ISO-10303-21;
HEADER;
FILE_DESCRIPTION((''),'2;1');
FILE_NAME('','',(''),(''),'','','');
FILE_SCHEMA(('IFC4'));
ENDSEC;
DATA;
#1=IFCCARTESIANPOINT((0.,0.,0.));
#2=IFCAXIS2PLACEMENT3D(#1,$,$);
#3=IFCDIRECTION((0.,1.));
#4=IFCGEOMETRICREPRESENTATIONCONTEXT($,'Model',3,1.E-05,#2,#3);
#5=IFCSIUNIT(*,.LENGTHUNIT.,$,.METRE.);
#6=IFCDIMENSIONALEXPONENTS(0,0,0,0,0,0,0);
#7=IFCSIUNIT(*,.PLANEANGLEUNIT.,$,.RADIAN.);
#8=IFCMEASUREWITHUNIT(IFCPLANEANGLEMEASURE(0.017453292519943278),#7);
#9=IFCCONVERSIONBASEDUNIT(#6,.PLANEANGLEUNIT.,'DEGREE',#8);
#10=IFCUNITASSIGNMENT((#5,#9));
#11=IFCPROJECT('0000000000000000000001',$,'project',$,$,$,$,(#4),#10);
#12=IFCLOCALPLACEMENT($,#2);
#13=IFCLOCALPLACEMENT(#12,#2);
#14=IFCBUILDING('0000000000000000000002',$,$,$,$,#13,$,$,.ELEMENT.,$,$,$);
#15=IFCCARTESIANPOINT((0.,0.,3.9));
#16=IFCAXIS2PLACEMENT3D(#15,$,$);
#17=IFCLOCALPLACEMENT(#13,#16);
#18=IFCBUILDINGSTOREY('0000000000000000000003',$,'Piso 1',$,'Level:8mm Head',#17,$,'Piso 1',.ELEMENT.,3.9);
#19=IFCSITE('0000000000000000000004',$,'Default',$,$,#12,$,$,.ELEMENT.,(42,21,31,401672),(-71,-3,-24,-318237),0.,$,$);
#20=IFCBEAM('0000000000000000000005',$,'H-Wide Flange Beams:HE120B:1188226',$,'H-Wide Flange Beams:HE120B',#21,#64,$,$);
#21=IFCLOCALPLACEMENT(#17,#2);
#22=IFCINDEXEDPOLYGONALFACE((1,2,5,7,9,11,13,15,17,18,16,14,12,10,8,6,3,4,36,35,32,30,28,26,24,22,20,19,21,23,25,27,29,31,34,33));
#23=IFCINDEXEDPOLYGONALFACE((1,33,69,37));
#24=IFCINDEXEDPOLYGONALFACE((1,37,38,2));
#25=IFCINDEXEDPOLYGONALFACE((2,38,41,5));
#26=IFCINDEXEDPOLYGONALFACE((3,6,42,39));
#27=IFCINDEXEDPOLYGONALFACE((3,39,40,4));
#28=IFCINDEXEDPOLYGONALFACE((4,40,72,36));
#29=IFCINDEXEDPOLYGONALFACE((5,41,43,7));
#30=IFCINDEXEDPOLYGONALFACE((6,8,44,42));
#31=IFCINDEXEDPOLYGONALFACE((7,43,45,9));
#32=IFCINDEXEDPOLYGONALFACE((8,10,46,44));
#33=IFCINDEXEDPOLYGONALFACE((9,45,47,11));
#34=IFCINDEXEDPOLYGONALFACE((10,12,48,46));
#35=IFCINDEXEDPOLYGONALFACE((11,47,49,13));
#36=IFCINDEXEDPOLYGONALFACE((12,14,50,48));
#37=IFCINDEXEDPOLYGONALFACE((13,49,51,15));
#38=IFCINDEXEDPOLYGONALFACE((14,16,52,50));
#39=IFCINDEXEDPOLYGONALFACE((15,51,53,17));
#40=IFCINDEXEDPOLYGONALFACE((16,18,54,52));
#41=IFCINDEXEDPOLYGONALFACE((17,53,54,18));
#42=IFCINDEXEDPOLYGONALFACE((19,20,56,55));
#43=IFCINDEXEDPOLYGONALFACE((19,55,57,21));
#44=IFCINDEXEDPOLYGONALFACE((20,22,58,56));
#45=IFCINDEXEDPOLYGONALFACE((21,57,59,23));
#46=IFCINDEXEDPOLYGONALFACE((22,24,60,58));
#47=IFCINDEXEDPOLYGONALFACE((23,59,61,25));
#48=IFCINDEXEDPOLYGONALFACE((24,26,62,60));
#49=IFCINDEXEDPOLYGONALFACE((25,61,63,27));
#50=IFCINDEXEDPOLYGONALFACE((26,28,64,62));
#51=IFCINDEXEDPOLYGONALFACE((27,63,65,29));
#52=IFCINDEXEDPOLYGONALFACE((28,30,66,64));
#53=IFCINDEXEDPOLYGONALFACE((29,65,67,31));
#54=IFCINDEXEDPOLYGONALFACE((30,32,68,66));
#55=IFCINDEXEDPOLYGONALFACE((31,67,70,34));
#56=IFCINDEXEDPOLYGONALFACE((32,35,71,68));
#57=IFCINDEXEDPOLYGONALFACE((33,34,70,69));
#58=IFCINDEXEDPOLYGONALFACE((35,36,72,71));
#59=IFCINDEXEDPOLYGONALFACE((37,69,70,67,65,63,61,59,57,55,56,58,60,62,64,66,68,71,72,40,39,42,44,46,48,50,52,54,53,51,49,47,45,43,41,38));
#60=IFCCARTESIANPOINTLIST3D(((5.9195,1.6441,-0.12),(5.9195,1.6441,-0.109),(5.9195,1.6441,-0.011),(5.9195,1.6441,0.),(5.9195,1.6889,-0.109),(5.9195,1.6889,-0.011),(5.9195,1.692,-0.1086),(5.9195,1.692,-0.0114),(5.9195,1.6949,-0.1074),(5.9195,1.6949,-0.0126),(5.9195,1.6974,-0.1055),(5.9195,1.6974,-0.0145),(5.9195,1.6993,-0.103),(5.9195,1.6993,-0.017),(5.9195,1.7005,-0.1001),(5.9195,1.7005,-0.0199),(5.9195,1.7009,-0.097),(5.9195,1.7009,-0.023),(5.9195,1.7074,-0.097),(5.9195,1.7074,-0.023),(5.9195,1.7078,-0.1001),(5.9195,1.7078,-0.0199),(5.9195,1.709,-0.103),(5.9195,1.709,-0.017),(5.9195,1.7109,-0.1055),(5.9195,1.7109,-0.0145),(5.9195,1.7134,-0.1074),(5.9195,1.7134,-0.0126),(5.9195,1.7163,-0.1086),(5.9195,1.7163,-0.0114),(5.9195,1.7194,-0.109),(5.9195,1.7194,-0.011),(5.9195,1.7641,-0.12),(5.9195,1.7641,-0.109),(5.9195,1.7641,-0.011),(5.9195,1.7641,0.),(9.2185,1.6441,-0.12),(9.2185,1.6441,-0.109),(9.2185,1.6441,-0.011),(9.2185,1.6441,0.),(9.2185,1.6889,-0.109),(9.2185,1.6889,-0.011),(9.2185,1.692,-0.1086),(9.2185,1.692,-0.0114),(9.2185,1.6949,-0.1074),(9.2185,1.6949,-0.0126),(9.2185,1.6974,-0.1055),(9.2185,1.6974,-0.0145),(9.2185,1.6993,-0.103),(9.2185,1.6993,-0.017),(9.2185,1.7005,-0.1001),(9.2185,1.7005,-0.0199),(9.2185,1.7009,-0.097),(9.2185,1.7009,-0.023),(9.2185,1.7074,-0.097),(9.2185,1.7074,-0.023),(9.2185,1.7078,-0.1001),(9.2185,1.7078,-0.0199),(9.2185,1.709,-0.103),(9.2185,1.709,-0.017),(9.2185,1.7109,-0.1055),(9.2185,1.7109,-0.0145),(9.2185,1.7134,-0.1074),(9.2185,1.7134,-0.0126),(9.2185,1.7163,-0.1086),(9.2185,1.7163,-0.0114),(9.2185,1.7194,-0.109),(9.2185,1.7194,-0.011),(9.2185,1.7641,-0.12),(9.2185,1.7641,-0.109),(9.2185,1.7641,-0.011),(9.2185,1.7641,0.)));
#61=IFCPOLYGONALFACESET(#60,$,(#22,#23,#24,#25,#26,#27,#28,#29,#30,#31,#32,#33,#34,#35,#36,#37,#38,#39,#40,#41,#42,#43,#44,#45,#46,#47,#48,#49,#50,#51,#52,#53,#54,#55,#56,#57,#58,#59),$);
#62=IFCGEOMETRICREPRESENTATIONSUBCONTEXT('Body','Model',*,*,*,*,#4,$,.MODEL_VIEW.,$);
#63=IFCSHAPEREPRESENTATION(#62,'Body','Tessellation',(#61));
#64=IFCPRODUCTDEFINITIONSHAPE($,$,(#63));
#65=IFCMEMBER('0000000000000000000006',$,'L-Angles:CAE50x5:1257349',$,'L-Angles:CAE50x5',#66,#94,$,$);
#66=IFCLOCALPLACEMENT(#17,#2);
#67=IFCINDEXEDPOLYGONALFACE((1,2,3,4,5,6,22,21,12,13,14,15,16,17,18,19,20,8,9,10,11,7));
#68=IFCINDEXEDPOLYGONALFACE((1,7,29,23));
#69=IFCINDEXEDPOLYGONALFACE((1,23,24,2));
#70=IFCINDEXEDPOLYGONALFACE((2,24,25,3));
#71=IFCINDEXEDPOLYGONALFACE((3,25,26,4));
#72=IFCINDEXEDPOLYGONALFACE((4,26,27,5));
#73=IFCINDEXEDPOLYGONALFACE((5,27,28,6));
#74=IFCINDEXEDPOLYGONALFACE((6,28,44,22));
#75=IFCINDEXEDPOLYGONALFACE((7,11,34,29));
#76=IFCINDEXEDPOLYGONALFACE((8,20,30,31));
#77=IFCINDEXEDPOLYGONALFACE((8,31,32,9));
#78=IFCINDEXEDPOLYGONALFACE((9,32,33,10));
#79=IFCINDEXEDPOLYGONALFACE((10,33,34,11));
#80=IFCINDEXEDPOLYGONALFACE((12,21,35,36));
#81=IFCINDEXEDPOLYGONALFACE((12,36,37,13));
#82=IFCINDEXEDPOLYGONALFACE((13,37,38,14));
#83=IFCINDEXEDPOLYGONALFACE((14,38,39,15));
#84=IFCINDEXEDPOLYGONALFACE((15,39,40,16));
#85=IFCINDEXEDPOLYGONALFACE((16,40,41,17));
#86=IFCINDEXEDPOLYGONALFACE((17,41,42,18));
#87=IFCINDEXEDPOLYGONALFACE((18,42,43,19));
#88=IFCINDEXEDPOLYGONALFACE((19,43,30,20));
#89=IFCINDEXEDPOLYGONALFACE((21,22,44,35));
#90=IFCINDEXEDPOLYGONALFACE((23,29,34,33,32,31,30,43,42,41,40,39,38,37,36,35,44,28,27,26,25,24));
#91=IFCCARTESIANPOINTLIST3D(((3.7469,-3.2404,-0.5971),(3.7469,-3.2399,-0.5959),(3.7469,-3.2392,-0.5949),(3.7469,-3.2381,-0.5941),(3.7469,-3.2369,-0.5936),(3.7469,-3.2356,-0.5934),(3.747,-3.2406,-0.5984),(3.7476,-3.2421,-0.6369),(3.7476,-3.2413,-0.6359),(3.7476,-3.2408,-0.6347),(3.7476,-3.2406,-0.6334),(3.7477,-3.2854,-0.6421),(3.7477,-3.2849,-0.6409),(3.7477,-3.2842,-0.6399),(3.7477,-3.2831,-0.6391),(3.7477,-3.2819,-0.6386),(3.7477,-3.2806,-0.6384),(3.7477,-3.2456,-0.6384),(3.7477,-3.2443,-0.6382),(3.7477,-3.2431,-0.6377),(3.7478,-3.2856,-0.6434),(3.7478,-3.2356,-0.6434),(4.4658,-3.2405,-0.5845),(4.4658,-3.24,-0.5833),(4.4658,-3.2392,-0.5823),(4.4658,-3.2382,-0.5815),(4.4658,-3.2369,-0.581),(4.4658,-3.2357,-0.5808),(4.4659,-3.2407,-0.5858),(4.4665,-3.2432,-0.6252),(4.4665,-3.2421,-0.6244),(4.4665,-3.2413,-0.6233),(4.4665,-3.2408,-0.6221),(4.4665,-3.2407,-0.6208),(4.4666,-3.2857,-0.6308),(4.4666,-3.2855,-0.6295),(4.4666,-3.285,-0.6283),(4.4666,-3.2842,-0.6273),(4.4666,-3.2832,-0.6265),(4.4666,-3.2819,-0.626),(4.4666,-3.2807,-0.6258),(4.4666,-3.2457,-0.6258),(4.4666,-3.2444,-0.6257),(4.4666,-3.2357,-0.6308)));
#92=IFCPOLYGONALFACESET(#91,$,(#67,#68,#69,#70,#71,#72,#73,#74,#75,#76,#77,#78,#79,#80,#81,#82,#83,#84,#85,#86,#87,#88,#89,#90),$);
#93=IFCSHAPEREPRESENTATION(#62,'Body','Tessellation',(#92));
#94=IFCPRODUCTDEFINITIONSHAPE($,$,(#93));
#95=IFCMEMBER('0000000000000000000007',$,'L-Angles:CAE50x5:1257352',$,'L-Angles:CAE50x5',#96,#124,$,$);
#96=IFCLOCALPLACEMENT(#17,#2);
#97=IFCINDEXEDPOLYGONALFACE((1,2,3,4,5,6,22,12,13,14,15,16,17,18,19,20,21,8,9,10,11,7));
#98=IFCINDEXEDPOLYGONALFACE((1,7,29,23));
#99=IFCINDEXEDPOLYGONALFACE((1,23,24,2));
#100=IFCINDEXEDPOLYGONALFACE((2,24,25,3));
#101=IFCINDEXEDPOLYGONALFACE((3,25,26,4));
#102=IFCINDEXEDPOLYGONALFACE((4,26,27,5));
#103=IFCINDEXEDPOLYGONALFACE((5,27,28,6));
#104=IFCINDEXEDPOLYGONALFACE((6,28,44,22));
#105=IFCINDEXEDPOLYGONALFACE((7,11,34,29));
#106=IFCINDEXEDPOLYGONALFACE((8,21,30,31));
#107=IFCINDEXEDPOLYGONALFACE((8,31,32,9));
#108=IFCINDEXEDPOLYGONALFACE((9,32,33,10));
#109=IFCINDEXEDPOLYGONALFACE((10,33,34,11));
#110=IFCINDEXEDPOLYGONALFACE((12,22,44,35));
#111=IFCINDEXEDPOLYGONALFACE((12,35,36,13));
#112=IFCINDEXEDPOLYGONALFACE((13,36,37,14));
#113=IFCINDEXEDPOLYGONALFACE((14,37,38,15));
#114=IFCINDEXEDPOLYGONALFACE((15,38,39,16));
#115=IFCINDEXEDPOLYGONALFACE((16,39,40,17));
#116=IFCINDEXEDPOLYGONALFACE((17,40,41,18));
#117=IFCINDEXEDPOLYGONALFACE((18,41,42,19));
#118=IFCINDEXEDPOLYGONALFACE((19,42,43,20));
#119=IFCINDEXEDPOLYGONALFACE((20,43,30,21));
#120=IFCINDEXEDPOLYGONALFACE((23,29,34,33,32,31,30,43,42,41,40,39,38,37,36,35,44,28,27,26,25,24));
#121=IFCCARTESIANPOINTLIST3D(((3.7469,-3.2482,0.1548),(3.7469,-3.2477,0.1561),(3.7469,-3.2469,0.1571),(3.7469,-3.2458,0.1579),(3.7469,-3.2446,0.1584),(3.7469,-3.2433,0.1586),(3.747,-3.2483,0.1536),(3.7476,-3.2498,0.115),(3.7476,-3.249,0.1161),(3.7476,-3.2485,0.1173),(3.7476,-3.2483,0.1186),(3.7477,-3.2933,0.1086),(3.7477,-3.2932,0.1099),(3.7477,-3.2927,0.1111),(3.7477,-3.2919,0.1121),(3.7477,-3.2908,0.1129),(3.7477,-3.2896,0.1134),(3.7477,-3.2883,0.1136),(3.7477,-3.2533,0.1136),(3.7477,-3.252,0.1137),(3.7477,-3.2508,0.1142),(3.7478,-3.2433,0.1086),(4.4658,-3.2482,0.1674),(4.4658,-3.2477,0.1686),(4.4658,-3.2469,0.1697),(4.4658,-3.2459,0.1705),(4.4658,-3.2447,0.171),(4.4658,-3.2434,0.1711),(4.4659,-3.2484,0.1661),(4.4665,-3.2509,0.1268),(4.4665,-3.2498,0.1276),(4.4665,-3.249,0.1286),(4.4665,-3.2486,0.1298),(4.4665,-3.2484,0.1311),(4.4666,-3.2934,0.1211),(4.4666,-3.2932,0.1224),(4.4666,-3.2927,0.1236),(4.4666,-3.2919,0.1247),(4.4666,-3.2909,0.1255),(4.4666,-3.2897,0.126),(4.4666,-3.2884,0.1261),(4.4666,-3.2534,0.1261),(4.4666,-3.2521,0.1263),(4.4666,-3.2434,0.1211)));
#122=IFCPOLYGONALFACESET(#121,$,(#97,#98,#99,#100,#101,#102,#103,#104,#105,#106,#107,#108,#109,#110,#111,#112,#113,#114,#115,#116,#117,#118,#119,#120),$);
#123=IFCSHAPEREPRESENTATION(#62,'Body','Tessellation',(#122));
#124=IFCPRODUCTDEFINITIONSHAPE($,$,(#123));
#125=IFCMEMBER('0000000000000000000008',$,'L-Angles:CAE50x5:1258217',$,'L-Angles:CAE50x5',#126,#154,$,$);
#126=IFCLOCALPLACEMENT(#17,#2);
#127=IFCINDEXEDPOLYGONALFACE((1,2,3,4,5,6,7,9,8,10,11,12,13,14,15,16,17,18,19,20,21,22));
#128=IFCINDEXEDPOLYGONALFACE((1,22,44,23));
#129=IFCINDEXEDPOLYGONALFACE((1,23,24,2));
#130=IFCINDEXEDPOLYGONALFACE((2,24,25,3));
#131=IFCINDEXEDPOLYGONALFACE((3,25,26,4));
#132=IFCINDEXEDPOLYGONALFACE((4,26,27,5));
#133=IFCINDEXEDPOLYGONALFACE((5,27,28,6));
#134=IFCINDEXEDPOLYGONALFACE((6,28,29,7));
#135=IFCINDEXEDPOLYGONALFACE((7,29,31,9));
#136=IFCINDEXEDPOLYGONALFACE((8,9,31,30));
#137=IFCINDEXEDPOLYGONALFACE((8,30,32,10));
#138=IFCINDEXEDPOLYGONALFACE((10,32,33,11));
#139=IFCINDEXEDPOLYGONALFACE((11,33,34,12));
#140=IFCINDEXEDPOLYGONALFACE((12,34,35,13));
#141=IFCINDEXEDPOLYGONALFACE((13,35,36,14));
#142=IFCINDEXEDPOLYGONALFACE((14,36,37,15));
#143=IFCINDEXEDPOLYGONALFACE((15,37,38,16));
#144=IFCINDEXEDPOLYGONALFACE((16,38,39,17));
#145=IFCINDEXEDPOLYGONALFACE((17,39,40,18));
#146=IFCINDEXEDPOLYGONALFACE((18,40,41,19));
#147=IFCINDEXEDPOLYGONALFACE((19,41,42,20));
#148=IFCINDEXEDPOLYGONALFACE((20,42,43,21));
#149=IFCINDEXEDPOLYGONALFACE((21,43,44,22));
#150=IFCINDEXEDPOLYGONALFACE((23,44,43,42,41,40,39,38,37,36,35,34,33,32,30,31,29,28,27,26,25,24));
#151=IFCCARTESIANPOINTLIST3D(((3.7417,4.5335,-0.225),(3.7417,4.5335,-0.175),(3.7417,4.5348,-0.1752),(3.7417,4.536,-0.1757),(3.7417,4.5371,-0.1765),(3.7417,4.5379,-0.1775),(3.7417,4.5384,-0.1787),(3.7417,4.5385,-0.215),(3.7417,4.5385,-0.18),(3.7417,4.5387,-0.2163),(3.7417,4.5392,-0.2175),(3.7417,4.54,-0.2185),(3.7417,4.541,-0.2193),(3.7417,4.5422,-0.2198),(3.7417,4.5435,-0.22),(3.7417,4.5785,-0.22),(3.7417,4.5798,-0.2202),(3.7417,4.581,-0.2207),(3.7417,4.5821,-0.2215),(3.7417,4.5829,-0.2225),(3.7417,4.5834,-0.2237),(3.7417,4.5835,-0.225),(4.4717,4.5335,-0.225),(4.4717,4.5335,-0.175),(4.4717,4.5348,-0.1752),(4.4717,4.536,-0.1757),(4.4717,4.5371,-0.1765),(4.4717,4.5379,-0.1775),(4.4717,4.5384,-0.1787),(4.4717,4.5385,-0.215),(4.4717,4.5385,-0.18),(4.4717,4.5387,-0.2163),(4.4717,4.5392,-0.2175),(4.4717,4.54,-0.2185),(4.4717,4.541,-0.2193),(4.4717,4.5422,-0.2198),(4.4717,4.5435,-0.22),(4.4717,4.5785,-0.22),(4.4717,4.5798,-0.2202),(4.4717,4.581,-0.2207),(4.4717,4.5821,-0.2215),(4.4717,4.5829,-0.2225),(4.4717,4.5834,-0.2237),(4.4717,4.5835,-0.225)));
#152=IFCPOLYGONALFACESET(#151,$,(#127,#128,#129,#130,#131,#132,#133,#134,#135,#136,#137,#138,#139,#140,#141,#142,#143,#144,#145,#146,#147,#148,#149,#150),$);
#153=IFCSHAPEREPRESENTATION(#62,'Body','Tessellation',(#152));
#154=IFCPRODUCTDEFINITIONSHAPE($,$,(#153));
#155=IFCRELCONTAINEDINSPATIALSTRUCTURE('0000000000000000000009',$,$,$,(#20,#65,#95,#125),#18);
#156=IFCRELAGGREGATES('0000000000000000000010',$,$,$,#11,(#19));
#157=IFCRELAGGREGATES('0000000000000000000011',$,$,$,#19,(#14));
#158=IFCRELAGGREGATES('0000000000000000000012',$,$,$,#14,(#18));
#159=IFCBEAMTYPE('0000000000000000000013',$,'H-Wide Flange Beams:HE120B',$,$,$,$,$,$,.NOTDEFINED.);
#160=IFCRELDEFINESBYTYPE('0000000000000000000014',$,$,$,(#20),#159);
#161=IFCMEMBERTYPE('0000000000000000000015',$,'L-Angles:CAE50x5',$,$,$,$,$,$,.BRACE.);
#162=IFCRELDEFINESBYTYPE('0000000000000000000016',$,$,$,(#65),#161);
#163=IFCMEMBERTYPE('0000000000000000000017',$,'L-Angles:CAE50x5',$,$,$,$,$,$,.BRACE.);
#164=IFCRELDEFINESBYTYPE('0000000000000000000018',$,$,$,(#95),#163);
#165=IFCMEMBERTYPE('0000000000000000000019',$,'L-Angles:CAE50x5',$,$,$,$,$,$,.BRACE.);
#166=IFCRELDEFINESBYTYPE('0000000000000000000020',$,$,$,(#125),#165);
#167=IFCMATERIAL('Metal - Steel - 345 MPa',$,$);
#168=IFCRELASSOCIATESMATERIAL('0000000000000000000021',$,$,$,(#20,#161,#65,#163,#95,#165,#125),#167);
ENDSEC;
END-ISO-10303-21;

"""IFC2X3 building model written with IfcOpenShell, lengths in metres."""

from ifc_helpers import new_model, entity, si_unit, converted_unit, direction, frame, frame_2d, origin, place, context, subcontext, project, spatial, polyline, circle_curve, parameter, trimmed, segment, composite_curve, i_section, outline, extrude, source, transform, mapped, material, type_object, type_shapes, element, save


model = new_model("IFC2X3")

# Units and contexts
model_context = context("Model", 3, precision=1e-05, world=origin(), true_north=direction((0.0, 1.0)))
body_context = subcontext(model_context, "Body", "Model", "MODEL_VIEW")
ifc_project = project(units=[si_unit("LENGTHUNIT", "METRE"), converted_unit("PLANEANGLEUNIT", "DEGREE", entity("IfcPlaneAngleMeasure", 0.017453292519943278), si_unit("PLANEANGLEUNIT", "RADIAN"), dimensions=[0, 0, 0, 0, 0, 0, 0])], contexts=[model_context])

# Site, building, storey
site_placement = place(None, origin())
site = spatial("IfcSite", under=ifc_project, at=site_placement, Name="Default", CompositionType="ELEMENT", RefLatitude=(42, 21, 31, 401672), RefLongitude=(-71, -3, -24, -318237), RefElevation=0.0)
building_placement = place(site_placement, origin())
building = spatial("IfcBuilding", under=site, at=building_placement, CompositionType="ELEMENT")
storey_placement = place(building_placement, frame((0.0, 0.0, 3.9)))
storey = spatial("IfcBuildingStorey", under=building, at=storey_placement, Name="Piso 1", ObjectType="Level:8mm Head", LongName="Piso 1", CompositionType="ELEMENT", Elevation=3.9)

# Beam
ifc_material_1 = material(Name="Metal - Steel - 345 MPa")
beam_type_1 = type_object("IfcBeamType", Name="H-Wide Flange Beams:HE120B", PredefinedType="NOTDEFINED")
beam_1_placement = place(storey_placement, frame((5.8465, 1.7041, 0.0)))
element("IfcBeam", 1, at=beam_1_placement, inside=storey, type_object=beam_type_1, material=ifc_material_1, Name="H-Wide Flange Beams:HE120B:1188226", ObjectType="H-Wide Flange Beams:HE120B", context=body_context, shape_type="SweptSolid", body=[
    extrude(i_section(OverallWidth=0.12, OverallDepth=0.12, WebThickness=0.0065, FlangeThickness=0.011, FilletRadius=0.012, at=frame_2d((0.0, 0.0), x_axis=(0.0, 1.0))), frame((0.073, 0.0, -0.06), z_axis=(1.0, 0.0, 0.0), x_axis=(0.0, 0.0, -1.0)), (0.0, 0.0, 1.0), 3.299),
])

# Members
member_type_1 = type_object("IfcMemberType", Name="L-Angles:CAE50x5", PredefinedType="BRACE", material=ifc_material_1)
shared_shape_1 = source(origin(), body_context, "Body", "SweptSolid", [
    extrude(outline(composite_curve([segment(polyline([(-0.0164, -0.0164), (0.0336, -0.0164)]), True, "CONTINUOUS"), segment(trimmed(circle_curve(frame_2d((0.0286, -0.0164), x_axis=(1.0, 0.0)), 0.005), [parameter(0.0)], [parameter(90.0)], True, "PARAMETER"), True, "CONTINUOUS"), segment(polyline([(0.0286, -0.0114), (-0.0064, -0.0114)]), True, "CONTINUOUS"), segment(trimmed(circle_curve(frame_2d((-0.0064, -0.0064), x_axis=(1.0, 0.0)), 0.005), [parameter(180.0)], [parameter(270.0)], True, "PARAMETER"), False, "CONTINUOUS"), segment(polyline([(-0.0114, -0.0064), (-0.0114, 0.0286)]), True, "CONTINUOUS"), segment(trimmed(circle_curve(frame_2d((-0.0164, 0.0286), x_axis=(1.0, 0.0)), 0.005), [parameter(0.0)], [parameter(90.0)], True, "PARAMETER"), True, "CONTINUOUS"), segment(polyline([(-0.0164, 0.0336), (-0.0164, -0.0164)]), True, "CONTINUOUS")], self_intersect=False)), frame((-0.359, -0.0024, -0.0024), z_axis=(1.0, 0.0, 0.0), x_axis=(0.0, -1.0, 0.0)), (0.0, 0.0, 1.0), 0.719),
])
type_shapes(member_type_1, [shared_shape_1])
member_1_placement = place(storey_placement, frame((4.1065, -3.2496, -0.6231), z_axis=(0.000052, 1.0, 0.0), x_axis=(0.999847, -0.000052, 0.017497)))
element("IfcMember", 2, at=member_1_placement, inside=storey, type_object=member_type_1, material=ifc_material_1, Name="L-Angles:CAE50x5:1257349", ObjectType="L-Angles:CAE50x5", context=body_context, shape_type="MappedRepresentation", body=[
    mapped(shared_shape_1, transform((0.0, 0.0, 0.0), scale=1.0)),
])
member_type_2 = type_object("IfcMemberType", Name="L-Angles:CAE50x5", PredefinedType="BRACE", material=ifc_material_1)
shared_shape_2 = source(origin(), body_context, "Body", "SweptSolid", [
    extrude(outline(composite_curve([segment(polyline([(-0.0164, -0.0164), (0.0336, -0.0164)]), True, "CONTINUOUS"), segment(trimmed(circle_curve(frame_2d((0.0286, -0.0164), x_axis=(1.0, 0.0)), 0.005), [parameter(0.0)], [parameter(90.0)], True, "PARAMETER"), True, "CONTINUOUS"), segment(polyline([(0.0286, -0.0114), (-0.0064, -0.0114)]), True, "CONTINUOUS"), segment(trimmed(circle_curve(frame_2d((-0.0064, -0.0064), x_axis=(1.0, 0.0)), 0.005), [parameter(180.0)], [parameter(270.0)], True, "PARAMETER"), False, "CONTINUOUS"), segment(polyline([(-0.0114, -0.0064), (-0.0114, 0.0286)]), True, "CONTINUOUS"), segment(trimmed(circle_curve(frame_2d((-0.0164, 0.0286), x_axis=(1.0, 0.0)), 0.005), [parameter(0.0)], [parameter(90.0)], True, "PARAMETER"), True, "CONTINUOUS"), segment(polyline([(-0.0164, 0.0336), (-0.0164, -0.0164)]), True, "CONTINUOUS")], self_intersect=False)), frame((-0.359, -0.0024, -0.0024), z_axis=(1.0, 0.0, 0.0), x_axis=(0.0, -1.0, 0.0)), (0.0, 0.0, 1.0), 0.719),
])
type_shapes(member_type_2, [shared_shape_2])
member_2_placement = place(storey_placement, frame((4.1065, -3.2574, 0.1288), z_axis=(0.000069, 1.0, 0.0), x_axis=(0.999847, -0.000069, 0.017497)))
element("IfcMember", 3, at=member_2_placement, inside=storey, type_object=member_type_2, material=ifc_material_1, Name="L-Angles:CAE50x5:1257352", ObjectType="L-Angles:CAE50x5", context=body_context, shape_type="MappedRepresentation", body=[
    mapped(shared_shape_2, transform((0.0, 0.0, 0.0), scale=1.0)),
])
member_type_3 = type_object("IfcMemberType", Name="L-Angles:CAE50x5", PredefinedType="BRACE", material=ifc_material_1)
shared_shape_3 = source(origin(), body_context, "Body", "SweptSolid", [
    extrude(outline(composite_curve([segment(polyline([(-0.0164, -0.0164), (0.0336, -0.0164)]), True, "CONTINUOUS"), segment(trimmed(circle_curve(frame_2d((0.0286, -0.0164), x_axis=(1.0, 0.0)), 0.005), [parameter(0.0)], [parameter(90.0)], True, "PARAMETER"), True, "CONTINUOUS"), segment(polyline([(0.0286, -0.0114), (-0.0064, -0.0114)]), True, "CONTINUOUS"), segment(trimmed(circle_curve(frame_2d((-0.0064, -0.0064), x_axis=(1.0, 0.0)), 0.005), [parameter(180.0)], [parameter(270.0)], True, "PARAMETER"), False, "CONTINUOUS"), segment(polyline([(-0.0114, -0.0064), (-0.0114, 0.0286)]), True, "CONTINUOUS"), segment(trimmed(circle_curve(frame_2d((-0.0164, 0.0286), x_axis=(1.0, 0.0)), 0.005), [parameter(0.0)], [parameter(90.0)], True, "PARAMETER"), True, "CONTINUOUS"), segment(polyline([(-0.0164, 0.0336), (-0.0164, -0.0164)]), True, "CONTINUOUS")], self_intersect=False)), frame((-0.365, -0.0024, -0.0024), z_axis=(1.0, 0.0, 0.0), x_axis=(0.0, -1.0, 0.0)), (0.0, 0.0, 1.0), 0.73),
])
type_shapes(member_type_3, [shared_shape_3])
for number, where, z_axis, x_axis, name in (
    (4, (4.1067, 4.5475, -0.211), (0.0, -1.0, 0.0), (-1.0, 0.0, 0.0), "L-Angles:CAE50x5:1258217"),
):
    element("IfcMember", number, at=place(storey_placement, frame(where, z_axis=z_axis, x_axis=x_axis)), inside=storey, type_object=member_type_3, material=ifc_material_1, Name=name, ObjectType="L-Angles:CAE50x5", context=body_context, shape_type="MappedRepresentation", body=[
        mapped(shared_shape_3, transform((0.0, 0.0, 0.0), scale=1.0)),
    ])

save(model, "model.ifc")
